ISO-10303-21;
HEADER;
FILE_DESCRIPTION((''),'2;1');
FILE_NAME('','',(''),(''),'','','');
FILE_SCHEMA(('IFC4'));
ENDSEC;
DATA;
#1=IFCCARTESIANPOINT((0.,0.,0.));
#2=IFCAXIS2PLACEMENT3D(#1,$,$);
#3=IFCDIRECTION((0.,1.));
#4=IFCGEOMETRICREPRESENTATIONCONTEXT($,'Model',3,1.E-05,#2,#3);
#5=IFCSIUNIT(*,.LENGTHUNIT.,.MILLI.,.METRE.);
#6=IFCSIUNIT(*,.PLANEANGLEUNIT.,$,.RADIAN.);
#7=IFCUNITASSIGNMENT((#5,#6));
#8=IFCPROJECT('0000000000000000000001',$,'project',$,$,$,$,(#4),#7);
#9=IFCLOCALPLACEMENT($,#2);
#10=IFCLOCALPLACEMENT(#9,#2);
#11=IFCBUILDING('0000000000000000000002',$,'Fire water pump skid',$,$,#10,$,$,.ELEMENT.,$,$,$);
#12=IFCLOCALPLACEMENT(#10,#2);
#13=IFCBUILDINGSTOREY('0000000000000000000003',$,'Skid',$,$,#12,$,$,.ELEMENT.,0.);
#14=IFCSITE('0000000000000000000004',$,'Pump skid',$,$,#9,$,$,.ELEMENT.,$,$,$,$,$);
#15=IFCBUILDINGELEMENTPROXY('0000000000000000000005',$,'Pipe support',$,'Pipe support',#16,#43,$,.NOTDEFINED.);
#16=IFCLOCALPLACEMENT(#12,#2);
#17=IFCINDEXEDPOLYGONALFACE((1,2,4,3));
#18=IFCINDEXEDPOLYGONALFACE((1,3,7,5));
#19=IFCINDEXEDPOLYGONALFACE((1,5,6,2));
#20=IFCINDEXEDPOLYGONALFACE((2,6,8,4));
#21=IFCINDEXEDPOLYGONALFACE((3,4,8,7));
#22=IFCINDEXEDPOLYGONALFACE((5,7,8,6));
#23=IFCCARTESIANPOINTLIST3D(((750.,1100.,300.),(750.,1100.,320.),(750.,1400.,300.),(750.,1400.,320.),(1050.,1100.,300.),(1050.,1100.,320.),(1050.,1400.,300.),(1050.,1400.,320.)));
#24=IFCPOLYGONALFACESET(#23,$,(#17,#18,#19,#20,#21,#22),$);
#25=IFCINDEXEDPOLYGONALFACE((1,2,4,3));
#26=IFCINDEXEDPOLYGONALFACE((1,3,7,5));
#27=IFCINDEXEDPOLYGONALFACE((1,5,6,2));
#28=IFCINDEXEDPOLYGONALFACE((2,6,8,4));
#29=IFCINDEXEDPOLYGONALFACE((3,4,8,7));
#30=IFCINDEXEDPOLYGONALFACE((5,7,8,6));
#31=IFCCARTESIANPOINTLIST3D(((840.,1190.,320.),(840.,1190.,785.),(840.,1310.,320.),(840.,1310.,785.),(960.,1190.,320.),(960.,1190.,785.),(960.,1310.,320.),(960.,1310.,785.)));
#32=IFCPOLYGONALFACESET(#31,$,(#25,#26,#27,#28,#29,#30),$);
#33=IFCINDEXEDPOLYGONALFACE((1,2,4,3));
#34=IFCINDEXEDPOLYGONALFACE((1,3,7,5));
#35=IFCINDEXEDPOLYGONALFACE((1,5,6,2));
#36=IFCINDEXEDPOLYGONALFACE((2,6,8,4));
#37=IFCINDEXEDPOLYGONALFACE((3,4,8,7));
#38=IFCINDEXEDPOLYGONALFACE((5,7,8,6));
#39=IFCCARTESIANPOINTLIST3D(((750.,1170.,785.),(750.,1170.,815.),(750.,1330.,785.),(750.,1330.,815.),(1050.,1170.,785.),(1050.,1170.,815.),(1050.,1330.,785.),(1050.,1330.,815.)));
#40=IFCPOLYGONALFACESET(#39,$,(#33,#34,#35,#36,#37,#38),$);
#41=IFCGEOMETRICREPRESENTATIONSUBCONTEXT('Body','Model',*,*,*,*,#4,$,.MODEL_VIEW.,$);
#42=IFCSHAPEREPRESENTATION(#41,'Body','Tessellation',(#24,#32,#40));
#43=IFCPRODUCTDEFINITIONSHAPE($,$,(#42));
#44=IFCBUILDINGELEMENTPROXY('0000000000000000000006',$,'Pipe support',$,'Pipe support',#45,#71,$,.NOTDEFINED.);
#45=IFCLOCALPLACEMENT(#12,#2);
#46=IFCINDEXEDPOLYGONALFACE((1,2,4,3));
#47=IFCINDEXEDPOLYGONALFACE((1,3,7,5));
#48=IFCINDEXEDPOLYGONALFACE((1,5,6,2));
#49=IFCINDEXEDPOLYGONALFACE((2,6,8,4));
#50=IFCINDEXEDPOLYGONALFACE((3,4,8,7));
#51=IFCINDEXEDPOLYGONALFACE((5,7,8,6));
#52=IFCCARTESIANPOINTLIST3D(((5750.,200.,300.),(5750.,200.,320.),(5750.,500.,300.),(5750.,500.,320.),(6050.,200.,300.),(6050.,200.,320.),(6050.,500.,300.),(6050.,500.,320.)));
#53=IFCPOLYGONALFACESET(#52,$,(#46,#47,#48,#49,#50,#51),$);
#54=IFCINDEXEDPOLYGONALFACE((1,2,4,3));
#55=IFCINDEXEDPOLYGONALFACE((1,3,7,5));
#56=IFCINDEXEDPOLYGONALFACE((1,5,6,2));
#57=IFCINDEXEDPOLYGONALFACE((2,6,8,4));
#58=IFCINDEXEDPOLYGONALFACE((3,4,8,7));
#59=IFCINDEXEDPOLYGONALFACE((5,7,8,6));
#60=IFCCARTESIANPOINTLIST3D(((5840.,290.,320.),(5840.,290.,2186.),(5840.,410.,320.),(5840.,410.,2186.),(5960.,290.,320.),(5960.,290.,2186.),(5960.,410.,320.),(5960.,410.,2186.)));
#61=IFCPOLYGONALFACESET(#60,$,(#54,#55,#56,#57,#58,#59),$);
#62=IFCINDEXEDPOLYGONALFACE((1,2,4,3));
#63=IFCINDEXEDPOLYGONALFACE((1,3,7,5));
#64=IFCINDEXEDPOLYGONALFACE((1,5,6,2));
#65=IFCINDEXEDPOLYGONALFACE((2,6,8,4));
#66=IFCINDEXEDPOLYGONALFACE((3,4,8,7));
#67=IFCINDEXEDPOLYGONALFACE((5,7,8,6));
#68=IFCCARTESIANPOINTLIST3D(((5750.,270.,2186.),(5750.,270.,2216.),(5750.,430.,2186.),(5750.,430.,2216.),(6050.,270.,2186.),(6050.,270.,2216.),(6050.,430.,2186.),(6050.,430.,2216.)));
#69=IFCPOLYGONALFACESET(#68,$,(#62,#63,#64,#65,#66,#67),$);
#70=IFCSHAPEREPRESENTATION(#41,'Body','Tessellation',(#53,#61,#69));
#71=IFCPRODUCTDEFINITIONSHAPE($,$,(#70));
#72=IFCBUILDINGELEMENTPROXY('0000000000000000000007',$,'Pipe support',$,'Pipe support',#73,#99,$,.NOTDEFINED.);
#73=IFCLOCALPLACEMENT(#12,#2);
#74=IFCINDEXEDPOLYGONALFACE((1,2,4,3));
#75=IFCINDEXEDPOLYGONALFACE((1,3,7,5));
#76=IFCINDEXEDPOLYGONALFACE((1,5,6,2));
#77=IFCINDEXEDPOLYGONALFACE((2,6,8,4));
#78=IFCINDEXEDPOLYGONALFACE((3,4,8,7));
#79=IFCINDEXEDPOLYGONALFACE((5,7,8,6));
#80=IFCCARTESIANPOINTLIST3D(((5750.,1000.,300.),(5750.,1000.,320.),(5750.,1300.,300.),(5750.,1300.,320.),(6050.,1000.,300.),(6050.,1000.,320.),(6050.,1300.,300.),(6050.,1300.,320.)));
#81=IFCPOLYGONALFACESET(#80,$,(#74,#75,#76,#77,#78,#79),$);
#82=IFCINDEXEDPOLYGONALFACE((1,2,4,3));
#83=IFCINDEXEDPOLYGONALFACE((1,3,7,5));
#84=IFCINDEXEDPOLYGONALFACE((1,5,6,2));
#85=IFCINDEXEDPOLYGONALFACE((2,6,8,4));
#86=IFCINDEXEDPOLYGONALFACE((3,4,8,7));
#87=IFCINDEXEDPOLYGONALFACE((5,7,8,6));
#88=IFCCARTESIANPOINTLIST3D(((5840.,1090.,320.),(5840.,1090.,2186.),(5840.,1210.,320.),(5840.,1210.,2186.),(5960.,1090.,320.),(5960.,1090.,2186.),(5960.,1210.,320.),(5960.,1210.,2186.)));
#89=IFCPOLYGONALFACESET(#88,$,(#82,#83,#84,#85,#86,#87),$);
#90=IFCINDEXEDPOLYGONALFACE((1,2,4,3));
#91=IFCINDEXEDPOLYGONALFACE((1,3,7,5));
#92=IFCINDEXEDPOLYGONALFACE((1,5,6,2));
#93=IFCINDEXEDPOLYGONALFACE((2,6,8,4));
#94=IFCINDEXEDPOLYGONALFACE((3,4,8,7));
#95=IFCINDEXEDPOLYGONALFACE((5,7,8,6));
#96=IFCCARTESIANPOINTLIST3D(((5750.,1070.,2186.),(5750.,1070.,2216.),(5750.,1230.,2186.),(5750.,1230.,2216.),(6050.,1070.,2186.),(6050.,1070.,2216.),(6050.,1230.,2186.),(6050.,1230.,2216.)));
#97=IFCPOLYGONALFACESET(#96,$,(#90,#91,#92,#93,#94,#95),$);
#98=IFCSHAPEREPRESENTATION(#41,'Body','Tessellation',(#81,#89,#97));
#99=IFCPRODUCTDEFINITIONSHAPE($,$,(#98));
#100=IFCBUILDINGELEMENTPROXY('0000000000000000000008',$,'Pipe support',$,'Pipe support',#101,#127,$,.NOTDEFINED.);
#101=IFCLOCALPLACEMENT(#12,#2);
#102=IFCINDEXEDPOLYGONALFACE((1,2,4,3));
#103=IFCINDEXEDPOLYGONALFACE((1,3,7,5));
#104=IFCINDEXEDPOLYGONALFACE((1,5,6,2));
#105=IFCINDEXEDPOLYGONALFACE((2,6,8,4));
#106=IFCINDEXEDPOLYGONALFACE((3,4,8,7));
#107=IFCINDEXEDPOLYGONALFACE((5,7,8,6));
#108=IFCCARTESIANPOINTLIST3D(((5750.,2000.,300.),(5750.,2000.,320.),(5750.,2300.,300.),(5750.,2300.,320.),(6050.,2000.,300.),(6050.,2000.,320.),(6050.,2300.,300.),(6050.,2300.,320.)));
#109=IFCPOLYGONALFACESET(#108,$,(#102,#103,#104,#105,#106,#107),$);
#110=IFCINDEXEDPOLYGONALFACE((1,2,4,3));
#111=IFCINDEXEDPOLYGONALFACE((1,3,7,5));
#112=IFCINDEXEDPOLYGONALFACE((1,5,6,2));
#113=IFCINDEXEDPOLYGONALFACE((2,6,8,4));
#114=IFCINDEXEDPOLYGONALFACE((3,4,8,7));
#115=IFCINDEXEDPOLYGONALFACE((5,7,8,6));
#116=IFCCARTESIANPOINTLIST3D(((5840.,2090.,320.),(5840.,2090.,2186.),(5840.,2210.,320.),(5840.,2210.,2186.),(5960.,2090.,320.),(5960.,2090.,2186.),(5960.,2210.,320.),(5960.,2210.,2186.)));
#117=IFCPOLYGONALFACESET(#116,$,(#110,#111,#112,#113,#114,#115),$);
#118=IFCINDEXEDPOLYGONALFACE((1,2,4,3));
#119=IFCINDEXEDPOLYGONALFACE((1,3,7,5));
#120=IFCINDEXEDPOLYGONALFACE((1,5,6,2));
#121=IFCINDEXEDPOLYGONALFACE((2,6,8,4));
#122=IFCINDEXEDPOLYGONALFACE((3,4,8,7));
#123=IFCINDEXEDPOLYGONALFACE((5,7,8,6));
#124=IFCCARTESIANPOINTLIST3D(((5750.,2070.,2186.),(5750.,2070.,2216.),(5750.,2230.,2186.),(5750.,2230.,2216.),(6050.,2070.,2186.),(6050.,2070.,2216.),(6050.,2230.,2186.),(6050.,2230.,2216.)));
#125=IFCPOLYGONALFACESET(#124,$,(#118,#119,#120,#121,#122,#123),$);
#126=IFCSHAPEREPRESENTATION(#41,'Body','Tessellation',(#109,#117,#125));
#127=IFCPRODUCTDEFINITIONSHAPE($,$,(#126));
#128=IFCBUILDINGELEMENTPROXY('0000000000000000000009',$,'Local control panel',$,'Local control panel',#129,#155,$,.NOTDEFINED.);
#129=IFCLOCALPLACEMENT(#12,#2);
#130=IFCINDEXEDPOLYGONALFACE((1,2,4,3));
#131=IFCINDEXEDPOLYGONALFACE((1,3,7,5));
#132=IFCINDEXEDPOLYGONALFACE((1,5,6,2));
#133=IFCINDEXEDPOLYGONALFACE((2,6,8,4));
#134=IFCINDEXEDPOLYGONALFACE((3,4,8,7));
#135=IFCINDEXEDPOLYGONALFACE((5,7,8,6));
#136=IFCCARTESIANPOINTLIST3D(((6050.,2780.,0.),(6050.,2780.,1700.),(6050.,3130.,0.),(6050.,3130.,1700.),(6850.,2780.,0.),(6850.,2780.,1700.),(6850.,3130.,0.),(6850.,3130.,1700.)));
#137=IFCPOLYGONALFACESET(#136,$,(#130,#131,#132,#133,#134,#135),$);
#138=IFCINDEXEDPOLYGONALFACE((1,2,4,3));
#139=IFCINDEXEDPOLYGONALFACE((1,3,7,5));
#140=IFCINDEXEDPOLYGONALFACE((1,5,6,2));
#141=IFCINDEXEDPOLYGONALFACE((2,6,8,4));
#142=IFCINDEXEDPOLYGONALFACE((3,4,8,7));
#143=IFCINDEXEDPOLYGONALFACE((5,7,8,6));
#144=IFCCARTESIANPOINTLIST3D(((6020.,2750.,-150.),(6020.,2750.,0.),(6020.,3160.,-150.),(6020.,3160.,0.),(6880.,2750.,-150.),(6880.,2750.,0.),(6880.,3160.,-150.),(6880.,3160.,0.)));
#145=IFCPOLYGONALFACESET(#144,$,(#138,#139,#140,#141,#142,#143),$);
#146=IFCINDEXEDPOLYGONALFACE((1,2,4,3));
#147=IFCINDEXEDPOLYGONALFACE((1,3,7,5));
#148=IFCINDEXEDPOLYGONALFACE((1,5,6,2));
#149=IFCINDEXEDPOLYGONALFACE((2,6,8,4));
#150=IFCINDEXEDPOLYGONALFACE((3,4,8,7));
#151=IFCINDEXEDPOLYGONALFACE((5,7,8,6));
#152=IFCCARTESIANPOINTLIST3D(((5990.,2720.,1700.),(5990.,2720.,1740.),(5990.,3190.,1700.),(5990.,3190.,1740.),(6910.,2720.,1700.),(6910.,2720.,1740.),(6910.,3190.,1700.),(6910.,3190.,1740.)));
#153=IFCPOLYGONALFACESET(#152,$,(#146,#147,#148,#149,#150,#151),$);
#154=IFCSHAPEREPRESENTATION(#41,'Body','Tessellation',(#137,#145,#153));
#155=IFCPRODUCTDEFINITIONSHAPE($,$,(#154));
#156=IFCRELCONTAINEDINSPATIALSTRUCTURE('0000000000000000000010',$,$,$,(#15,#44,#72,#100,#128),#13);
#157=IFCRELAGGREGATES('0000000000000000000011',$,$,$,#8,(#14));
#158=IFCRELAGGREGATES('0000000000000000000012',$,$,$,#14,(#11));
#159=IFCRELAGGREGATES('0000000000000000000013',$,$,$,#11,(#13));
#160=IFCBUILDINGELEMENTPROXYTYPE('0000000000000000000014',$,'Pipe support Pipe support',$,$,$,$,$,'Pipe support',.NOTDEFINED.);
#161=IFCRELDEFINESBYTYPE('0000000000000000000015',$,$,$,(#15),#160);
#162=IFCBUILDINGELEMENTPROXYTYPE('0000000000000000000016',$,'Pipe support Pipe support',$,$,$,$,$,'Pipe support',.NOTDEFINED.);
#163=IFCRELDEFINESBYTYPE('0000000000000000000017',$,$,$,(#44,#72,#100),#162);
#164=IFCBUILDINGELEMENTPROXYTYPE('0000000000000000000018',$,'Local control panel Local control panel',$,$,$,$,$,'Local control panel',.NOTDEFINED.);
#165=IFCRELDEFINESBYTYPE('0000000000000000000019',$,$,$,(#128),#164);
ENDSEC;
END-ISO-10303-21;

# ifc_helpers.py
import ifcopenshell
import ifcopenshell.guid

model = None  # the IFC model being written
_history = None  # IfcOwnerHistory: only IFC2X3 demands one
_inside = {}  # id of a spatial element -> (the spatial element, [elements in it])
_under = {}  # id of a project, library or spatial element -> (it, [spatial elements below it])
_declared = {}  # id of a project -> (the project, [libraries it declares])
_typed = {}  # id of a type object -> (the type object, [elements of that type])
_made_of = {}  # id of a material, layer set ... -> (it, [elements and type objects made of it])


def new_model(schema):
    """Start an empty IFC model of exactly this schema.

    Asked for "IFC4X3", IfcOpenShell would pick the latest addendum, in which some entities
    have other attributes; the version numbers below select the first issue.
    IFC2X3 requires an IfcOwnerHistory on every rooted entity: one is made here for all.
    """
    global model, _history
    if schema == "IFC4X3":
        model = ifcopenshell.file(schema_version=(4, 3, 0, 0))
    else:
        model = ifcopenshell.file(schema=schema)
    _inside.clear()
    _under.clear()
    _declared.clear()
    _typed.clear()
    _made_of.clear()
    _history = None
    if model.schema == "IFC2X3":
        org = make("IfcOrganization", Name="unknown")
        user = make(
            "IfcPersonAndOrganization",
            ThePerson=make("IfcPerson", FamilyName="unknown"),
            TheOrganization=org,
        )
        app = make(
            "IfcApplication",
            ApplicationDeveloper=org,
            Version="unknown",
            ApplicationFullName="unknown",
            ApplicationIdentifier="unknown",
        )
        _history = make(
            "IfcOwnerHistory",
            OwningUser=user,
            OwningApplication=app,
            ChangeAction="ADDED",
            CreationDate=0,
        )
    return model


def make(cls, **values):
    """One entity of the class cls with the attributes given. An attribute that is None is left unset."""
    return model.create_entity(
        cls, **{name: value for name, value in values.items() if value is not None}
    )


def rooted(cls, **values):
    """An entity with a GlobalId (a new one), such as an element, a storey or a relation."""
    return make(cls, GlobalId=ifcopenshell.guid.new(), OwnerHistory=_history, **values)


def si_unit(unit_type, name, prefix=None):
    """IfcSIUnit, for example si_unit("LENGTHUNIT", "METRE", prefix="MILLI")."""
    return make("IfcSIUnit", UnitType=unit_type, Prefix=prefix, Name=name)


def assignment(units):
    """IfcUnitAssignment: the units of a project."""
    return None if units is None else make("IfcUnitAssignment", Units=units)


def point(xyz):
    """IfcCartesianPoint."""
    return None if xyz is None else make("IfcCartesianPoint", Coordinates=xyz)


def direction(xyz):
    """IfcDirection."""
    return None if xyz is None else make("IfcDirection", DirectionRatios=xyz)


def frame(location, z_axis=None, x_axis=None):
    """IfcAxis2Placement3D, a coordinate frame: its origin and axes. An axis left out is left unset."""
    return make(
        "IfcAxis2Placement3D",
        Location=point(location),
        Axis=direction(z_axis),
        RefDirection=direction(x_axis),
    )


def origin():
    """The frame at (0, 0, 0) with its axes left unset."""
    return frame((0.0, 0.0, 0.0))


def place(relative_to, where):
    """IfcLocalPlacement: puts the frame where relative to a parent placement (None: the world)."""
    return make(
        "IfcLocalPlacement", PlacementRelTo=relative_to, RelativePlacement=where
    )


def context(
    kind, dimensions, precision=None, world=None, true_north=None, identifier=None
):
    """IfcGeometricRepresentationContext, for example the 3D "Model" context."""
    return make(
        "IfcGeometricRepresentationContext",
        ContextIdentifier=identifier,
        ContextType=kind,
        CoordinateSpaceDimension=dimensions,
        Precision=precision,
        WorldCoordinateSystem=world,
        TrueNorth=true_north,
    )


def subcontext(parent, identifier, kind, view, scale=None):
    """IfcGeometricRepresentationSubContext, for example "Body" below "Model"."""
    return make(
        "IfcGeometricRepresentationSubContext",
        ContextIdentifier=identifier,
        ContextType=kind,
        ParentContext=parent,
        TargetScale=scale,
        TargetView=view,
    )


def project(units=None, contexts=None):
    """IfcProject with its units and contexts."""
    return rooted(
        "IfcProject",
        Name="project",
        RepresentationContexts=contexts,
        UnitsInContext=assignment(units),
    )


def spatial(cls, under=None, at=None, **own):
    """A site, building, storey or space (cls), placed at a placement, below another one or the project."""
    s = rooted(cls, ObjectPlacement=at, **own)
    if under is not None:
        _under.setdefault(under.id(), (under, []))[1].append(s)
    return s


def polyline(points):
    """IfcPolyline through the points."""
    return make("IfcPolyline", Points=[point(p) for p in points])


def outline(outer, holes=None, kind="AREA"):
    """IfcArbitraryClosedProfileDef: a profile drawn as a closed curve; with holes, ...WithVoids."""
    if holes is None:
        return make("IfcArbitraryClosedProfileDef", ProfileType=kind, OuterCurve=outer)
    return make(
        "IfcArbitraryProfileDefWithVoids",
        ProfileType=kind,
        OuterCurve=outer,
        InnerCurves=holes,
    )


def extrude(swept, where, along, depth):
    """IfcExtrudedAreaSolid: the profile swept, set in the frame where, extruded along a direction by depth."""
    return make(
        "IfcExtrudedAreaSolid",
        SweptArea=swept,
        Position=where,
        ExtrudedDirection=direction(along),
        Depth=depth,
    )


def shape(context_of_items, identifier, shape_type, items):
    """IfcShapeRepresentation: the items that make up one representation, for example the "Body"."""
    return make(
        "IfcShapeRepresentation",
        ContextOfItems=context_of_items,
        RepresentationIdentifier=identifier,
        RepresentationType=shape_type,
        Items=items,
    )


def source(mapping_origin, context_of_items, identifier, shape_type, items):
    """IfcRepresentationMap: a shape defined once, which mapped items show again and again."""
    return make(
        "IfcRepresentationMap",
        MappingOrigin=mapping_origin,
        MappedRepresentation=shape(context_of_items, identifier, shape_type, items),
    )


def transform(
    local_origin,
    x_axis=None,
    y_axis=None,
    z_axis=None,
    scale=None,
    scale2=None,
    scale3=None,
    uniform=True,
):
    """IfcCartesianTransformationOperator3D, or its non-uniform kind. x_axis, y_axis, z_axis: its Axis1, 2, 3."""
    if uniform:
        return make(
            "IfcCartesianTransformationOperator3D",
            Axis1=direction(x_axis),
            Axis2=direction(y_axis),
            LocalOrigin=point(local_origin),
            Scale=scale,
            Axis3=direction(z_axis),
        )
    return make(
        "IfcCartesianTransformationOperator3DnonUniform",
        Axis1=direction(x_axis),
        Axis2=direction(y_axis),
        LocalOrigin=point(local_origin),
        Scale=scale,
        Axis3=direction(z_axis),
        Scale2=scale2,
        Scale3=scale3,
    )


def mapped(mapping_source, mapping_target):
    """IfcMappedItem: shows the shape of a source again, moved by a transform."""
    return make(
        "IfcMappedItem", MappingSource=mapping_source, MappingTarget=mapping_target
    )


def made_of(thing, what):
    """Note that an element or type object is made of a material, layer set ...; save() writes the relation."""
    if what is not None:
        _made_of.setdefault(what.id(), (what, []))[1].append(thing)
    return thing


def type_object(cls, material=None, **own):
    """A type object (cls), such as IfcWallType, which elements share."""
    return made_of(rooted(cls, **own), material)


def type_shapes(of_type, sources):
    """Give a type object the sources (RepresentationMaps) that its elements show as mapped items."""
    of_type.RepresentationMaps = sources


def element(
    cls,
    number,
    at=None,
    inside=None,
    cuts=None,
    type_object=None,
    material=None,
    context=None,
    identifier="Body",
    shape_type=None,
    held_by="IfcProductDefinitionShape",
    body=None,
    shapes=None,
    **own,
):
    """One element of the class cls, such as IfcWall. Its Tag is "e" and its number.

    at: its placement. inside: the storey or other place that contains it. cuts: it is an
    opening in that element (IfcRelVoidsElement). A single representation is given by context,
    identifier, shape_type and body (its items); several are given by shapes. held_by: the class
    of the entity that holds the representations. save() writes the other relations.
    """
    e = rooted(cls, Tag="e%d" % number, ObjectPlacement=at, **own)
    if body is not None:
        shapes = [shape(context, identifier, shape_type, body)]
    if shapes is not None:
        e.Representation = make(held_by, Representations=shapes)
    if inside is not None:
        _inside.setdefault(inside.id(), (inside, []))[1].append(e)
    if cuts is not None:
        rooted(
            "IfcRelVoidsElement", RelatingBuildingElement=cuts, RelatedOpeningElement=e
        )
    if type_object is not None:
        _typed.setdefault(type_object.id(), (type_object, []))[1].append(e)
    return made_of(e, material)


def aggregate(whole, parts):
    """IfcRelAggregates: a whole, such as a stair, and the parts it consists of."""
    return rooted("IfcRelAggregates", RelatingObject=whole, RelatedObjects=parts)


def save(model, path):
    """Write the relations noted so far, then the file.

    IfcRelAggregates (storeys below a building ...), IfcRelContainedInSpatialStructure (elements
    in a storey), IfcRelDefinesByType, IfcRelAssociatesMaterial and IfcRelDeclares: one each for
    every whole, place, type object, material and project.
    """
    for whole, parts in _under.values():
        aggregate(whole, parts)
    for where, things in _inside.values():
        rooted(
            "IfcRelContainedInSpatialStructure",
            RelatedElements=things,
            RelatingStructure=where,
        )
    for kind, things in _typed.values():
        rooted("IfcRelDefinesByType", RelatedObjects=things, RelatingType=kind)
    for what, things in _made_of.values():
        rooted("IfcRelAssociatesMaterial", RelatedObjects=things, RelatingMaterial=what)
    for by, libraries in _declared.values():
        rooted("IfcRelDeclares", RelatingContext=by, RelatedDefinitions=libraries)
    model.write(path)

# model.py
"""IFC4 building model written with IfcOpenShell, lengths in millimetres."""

from ifc_helpers import new_model, si_unit, direction, frame, origin, place, context, subcontext, project, spatial, polyline, outline, extrude, source, transform, mapped, type_object, type_shapes, element, save


model = new_model("IFC4")

# Units and contexts
model_context = context("Model", 3, precision=1e-05, world=origin(), true_north=direction((0.0, 1.0)))
body_context = subcontext(model_context, "Body", "Model", "MODEL_VIEW")
ifc_project = project(units=[si_unit("LENGTHUNIT", "METRE", prefix="MILLI"), si_unit("PLANEANGLEUNIT", "RADIAN")], contexts=[model_context])

# Site, building, storey
site_placement = place(None, origin())
site = spatial("IfcSite", under=ifc_project, at=site_placement, Name="Pump skid", CompositionType="ELEMENT")
building_placement = place(site_placement, origin())
building = spatial("IfcBuilding", under=site, at=building_placement, Name="Fire water pump skid", CompositionType="ELEMENT")
storey_placement = place(building_placement, origin())
storey = spatial("IfcBuildingStorey", under=building, at=storey_placement, Name="Skid", CompositionType="ELEMENT", Elevation=0.0)

# Building element proxies
building_element_proxy_type_1 = type_object("IfcBuildingElementProxyType", Name="Pipe support Pipe support", ElementType="Pipe support", PredefinedType="NOTDEFINED")
shared_shape_1 = source(origin(), body_context, "Body", "SweptSolid", [
    extrude(outline(polyline([(-150.0, -150.0), (150.0, -150.0), (150.0, 150.0), (-150.0, 150.0), (-150.0, -150.0)])), frame((0.0, 0.0, 300.0)), (0.0, 0.0, 1.0), 20.0),
    extrude(outline(polyline([(-60.0, -60.0), (60.0, -60.0), (60.0, 60.0), (-60.0, 60.0), (-60.0, -60.0)])), frame((0.0, 0.0, 320.0)), (0.0, 0.0, 1.0), 465.0),
    extrude(outline(polyline([(-150.0, -80.0), (150.0, -80.0), (150.0, 80.0), (-150.0, 80.0), (-150.0, -80.0)])), frame((0.0, 0.0, 785.0)), (0.0, 0.0, 1.0), 30.0),
])
type_shapes(building_element_proxy_type_1, [shared_shape_1])
for number, where, z_axis, x_axis, name in (
    (1, (900.0, 1250.0, 0.0), (0.0, 0.0, 1.0), (1.0, 0.0, 0.0), "Pipe support"),
):
    element("IfcBuildingElementProxy", number, at=place(storey_placement, frame(where, z_axis=z_axis, x_axis=x_axis)), inside=storey, type_object=building_element_proxy_type_1, Name=name, ObjectType="Pipe support", PredefinedType="NOTDEFINED", context=body_context, shape_type="MappedRepresentation", body=[
        mapped(shared_shape_1, transform((0.0, 0.0, 0.0))),
    ])
building_element_proxy_type_2 = type_object("IfcBuildingElementProxyType", Name="Pipe support Pipe support", ElementType="Pipe support", PredefinedType="NOTDEFINED")
shared_shape_2 = source(origin(), body_context, "Body", "SweptSolid", [
    extrude(outline(polyline([(-150.0, -150.0), (150.0, -150.0), (150.0, 150.0), (-150.0, 150.0), (-150.0, -150.0)])), frame((0.0, 0.0, 300.0)), (0.0, 0.0, 1.0), 20.0),
    extrude(outline(polyline([(-60.0, -60.0), (60.0, -60.0), (60.0, 60.0), (-60.0, 60.0), (-60.0, -60.0)])), frame((0.0, 0.0, 320.0)), (0.0, 0.0, 1.0), 1866.0),
    extrude(outline(polyline([(-150.0, -80.0), (150.0, -80.0), (150.0, 80.0), (-150.0, 80.0), (-150.0, -80.0)])), frame((0.0, 0.0, 2186.0)), (0.0, 0.0, 1.0), 30.0),
])
type_shapes(building_element_proxy_type_2, [shared_shape_2])
for number, where, z_axis, x_axis, name in (
    (2, (5900.0, 350.0, 0.0), (0.0, 0.0, 1.0), (1.0, 0.0, 0.0), "Pipe support"),
    (3, (5900.0, 1150.0, 0.0), (0.0, 0.0, 1.0), (1.0, 0.0, 0.0), "Pipe support"),
    (4, (5900.0, 2150.0, 0.0), (0.0, 0.0, 1.0), (1.0, 0.0, 0.0), "Pipe support"),
):
    element("IfcBuildingElementProxy", number, at=place(storey_placement, frame(where, z_axis=z_axis, x_axis=x_axis)), inside=storey, type_object=building_element_proxy_type_2, Name=name, ObjectType="Pipe support", PredefinedType="NOTDEFINED", context=body_context, shape_type="MappedRepresentation", body=[
        mapped(shared_shape_2, transform((0.0, 0.0, 0.0))),
    ])
building_element_proxy_type_3 = type_object("IfcBuildingElementProxyType", Name="Local control panel Local control panel", ElementType="Local control panel", PredefinedType="NOTDEFINED")
shared_shape_3 = source(origin(), body_context, "Body", "SweptSolid", [
    extrude(outline(polyline([(0.0, 0.0), (800.0, 0.0), (800.0, 350.0), (0.0, 350.0), (0.0, 0.0)])), origin(), (0.0, 0.0, 1.0), 1700.0),
    extrude(outline(polyline([(-30.0, -30.0), (830.0, -30.0), (830.0, 380.0), (-30.0, 380.0), (-30.0, -30.0)])), frame((0.0, 0.0, -150.0)), (0.0, 0.0, 1.0), 150.0),
    extrude(outline(polyline([(-60.0, -60.0), (860.0, -60.0), (860.0, 410.0), (-60.0, 410.0), (-60.0, -60.0)])), frame((0.0, 0.0, 1700.0)), (0.0, 0.0, 1.0), 40.0),
])
type_shapes(building_element_proxy_type_3, [shared_shape_3])
proxy_placement = place(storey_placement, frame((6050.0, 2780.0, 0.0), z_axis=(0.0, 0.0, 1.0), x_axis=(1.0, 0.0, 0.0)))
element("IfcBuildingElementProxy", 5, at=proxy_placement, inside=storey, type_object=building_element_proxy_type_3, Name="Local control panel", ObjectType="Local control panel", PredefinedType="NOTDEFINED", context=body_context, shape_type="MappedRepresentation", body=[
    mapped(shared_shape_3, transform((0.0, 0.0, 0.0))),
])

save(model, "model.ifc")
